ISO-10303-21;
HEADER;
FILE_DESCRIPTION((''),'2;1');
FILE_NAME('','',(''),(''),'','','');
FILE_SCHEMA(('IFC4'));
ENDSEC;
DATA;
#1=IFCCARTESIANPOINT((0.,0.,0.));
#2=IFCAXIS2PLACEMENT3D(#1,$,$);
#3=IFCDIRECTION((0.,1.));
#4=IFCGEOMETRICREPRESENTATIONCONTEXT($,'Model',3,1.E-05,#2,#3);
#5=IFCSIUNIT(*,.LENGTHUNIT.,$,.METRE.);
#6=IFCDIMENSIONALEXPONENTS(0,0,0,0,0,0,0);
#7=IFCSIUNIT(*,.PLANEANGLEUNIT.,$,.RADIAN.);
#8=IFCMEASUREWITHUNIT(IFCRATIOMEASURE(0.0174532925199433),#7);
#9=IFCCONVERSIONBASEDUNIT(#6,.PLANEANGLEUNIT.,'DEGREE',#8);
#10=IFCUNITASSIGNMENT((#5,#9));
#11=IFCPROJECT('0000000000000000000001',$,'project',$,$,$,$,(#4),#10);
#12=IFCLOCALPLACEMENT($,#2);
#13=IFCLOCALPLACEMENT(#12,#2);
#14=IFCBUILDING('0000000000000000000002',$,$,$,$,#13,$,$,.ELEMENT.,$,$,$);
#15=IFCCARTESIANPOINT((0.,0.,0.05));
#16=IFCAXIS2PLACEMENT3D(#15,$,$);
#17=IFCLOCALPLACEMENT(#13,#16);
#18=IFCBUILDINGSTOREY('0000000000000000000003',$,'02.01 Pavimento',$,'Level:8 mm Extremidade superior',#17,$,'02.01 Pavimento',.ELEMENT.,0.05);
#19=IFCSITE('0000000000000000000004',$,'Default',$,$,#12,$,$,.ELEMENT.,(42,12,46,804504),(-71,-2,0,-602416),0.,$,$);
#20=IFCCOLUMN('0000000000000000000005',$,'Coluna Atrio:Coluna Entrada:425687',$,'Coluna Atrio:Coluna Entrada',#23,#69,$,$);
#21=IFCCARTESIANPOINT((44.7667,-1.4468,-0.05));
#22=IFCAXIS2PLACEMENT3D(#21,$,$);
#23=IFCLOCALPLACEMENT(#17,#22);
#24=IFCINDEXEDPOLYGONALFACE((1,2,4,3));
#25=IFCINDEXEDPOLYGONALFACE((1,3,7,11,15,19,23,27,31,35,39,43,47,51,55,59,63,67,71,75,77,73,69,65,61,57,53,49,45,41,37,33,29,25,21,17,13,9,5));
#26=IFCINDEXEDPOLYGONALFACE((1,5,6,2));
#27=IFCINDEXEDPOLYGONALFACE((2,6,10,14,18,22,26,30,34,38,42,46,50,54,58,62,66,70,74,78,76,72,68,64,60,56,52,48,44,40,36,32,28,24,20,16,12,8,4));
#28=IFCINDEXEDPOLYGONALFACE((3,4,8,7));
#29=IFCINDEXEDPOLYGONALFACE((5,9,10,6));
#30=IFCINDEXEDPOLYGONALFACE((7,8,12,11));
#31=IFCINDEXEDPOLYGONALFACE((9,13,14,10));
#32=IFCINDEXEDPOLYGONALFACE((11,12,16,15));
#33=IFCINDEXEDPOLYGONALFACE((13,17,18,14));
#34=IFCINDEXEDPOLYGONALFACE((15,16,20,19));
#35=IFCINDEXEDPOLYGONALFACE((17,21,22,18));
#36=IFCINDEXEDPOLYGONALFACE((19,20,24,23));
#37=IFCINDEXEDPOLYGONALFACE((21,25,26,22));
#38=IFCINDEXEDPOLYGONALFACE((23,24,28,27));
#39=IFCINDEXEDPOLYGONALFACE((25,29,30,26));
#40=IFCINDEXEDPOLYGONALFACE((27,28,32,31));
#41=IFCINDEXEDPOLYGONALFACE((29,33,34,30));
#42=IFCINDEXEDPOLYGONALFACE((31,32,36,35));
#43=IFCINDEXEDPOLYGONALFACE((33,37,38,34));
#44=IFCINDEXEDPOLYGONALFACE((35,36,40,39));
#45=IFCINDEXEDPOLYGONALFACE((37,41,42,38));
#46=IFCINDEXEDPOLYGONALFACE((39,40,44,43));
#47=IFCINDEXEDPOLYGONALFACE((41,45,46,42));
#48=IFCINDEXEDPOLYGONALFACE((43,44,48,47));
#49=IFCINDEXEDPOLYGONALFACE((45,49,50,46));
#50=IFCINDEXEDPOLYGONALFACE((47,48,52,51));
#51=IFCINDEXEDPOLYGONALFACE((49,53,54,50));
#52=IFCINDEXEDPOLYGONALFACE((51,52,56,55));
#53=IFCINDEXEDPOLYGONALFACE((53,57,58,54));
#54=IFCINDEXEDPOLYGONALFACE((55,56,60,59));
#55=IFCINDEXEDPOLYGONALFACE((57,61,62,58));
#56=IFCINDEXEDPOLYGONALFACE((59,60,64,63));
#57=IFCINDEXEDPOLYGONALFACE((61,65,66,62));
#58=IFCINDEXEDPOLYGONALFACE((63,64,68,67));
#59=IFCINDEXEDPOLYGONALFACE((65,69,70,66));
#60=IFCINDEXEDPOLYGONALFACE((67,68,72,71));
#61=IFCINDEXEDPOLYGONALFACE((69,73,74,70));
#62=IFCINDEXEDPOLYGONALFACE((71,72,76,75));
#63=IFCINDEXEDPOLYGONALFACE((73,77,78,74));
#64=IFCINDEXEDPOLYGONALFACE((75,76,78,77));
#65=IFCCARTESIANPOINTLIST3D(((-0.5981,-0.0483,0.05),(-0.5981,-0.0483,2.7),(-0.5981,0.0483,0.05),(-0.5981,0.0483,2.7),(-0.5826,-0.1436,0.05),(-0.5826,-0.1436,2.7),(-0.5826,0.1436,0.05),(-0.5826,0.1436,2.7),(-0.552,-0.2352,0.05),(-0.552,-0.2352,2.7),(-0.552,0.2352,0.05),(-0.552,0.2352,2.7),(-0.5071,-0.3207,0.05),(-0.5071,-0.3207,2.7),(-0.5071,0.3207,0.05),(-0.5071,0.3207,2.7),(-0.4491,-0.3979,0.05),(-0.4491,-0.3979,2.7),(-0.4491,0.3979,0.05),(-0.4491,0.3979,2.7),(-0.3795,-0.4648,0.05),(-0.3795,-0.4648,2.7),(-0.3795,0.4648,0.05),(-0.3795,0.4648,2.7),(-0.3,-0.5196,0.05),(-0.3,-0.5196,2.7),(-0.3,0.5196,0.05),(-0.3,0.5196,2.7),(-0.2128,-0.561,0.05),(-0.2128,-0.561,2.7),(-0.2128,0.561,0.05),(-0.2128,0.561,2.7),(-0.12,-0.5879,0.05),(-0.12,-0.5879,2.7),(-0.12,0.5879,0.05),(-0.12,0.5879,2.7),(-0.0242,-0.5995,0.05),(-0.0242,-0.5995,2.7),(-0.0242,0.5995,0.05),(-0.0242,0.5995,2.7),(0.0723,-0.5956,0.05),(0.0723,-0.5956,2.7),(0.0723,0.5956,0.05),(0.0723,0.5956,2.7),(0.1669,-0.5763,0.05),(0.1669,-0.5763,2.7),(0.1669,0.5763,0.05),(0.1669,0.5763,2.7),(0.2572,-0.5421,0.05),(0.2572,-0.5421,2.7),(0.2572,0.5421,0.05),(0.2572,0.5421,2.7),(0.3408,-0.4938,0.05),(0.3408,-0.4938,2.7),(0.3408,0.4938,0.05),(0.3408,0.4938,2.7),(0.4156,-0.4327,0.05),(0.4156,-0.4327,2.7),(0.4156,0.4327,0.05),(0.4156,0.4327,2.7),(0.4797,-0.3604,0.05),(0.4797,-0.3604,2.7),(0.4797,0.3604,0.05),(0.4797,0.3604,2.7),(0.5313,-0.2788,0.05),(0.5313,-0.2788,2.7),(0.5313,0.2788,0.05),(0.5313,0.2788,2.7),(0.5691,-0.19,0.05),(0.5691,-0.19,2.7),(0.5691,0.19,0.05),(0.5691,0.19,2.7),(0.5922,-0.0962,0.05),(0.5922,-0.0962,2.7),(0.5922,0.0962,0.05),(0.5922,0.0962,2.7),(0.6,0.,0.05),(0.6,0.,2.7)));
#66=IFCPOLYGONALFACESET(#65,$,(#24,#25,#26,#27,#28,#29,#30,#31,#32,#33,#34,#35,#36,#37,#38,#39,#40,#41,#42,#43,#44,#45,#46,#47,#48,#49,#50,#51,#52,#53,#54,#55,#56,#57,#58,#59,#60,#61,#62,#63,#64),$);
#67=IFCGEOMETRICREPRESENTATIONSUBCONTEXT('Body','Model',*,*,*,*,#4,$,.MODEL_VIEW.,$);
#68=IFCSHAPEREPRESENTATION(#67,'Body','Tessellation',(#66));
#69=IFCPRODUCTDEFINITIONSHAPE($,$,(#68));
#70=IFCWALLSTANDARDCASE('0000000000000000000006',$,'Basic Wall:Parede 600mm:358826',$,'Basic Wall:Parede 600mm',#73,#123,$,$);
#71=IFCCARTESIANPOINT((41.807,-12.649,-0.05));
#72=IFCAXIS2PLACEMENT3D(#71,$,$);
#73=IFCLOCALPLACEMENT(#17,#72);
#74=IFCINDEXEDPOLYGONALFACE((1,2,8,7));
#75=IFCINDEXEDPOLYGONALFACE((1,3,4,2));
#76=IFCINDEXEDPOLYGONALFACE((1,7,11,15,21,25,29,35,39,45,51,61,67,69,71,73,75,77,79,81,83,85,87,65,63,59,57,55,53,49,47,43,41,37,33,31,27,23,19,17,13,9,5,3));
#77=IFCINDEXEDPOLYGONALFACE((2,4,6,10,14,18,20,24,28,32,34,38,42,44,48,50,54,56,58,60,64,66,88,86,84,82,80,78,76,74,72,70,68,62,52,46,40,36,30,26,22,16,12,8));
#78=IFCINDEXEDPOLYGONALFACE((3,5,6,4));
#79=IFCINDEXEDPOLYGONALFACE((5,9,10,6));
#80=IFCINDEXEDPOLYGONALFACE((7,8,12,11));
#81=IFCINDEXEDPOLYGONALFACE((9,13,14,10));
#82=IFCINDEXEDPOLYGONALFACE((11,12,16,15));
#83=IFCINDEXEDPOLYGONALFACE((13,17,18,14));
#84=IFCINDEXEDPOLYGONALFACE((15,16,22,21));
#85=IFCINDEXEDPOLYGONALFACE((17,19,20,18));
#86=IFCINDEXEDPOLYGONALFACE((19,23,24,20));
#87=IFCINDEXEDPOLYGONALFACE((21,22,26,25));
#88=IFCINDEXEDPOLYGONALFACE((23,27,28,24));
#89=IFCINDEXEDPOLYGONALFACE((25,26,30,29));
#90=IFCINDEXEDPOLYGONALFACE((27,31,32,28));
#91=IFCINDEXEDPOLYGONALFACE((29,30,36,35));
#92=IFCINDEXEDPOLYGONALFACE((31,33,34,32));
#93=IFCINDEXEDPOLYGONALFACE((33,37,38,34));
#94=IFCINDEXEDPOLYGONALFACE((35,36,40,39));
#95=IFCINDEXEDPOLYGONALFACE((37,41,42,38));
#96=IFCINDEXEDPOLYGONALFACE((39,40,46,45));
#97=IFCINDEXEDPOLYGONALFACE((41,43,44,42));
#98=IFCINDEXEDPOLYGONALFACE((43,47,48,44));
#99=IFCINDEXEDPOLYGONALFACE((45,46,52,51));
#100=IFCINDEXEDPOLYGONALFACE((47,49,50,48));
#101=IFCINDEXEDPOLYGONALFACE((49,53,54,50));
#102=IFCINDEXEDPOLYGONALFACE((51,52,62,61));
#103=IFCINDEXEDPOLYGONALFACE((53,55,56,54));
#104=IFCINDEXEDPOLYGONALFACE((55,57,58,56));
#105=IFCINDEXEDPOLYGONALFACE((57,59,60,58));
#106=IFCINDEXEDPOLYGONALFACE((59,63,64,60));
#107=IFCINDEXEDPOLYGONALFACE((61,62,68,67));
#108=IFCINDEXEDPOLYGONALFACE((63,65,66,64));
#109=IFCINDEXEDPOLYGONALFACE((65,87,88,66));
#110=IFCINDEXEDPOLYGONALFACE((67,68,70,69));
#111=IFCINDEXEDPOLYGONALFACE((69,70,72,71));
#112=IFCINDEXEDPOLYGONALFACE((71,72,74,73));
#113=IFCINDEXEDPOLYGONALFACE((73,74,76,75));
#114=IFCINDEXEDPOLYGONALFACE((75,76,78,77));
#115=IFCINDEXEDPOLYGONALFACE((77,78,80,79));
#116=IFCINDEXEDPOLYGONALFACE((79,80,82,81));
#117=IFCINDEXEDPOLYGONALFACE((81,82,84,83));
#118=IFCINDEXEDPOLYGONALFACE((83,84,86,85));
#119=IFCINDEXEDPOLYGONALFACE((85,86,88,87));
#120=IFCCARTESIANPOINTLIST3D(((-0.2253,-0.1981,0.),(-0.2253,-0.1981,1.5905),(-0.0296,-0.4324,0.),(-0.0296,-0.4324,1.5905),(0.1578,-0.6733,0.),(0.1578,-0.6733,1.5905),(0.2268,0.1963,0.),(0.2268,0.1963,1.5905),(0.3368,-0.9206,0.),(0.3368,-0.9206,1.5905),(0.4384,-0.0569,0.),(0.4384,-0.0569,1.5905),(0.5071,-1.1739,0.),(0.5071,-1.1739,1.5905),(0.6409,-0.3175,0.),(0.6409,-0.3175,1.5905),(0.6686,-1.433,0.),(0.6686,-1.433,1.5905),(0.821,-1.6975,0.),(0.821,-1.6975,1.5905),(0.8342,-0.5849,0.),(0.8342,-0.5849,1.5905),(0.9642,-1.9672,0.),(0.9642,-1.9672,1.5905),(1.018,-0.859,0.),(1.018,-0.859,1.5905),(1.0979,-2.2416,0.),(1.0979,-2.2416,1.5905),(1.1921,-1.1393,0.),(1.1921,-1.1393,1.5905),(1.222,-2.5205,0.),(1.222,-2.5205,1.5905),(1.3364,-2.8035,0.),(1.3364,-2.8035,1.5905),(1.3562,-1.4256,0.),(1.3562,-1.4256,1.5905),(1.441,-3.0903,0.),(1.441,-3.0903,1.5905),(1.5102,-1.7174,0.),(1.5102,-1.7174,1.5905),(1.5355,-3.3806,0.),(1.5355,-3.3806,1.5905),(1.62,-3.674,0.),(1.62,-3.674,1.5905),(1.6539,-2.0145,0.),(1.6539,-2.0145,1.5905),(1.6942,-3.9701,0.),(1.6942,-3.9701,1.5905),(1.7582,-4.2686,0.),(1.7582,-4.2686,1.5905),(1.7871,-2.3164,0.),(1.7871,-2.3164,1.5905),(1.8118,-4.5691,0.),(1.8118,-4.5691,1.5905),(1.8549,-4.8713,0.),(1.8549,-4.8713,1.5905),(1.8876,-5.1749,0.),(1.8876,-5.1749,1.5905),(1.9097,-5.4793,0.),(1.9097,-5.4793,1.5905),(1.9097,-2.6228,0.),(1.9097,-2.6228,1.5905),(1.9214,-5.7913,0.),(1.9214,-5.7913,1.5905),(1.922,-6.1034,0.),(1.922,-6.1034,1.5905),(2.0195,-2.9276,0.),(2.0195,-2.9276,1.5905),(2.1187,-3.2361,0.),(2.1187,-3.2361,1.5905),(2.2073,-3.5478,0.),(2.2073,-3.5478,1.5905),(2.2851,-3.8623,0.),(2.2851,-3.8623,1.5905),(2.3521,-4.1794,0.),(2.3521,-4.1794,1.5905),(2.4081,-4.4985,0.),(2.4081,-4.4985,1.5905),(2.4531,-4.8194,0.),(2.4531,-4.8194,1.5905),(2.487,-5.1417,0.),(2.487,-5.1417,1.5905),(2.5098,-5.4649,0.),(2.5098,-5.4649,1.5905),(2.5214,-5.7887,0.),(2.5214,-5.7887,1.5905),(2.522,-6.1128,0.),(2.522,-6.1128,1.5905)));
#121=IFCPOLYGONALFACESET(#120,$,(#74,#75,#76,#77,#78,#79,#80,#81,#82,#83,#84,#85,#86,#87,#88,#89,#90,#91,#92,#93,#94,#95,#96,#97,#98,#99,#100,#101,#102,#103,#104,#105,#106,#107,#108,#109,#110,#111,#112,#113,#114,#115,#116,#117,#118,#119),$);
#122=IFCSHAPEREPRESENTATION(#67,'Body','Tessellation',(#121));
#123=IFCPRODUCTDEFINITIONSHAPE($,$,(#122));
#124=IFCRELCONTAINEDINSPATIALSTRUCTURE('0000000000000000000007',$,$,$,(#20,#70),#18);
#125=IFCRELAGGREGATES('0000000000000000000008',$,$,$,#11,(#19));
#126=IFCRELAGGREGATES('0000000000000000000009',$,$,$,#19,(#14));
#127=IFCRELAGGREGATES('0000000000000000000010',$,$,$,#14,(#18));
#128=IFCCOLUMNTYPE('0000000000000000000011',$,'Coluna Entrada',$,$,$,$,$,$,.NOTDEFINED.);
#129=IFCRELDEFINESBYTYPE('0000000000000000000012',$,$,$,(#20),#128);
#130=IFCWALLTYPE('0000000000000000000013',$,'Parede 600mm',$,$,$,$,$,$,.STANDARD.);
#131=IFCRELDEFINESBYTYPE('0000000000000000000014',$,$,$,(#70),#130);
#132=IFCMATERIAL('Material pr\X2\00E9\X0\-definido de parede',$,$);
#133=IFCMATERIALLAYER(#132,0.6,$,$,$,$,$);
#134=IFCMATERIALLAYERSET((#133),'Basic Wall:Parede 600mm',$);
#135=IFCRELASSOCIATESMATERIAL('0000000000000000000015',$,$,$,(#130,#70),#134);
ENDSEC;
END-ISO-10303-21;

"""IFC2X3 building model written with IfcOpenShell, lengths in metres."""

from ifc_helpers import new_model, entity, si_unit, converted_unit, direction, frame, frame_2d, origin, place, context, subcontext, project, spatial, polyline, circle, outline, extrude, clip, halfspace, source, transform, mapped, material, layer, layer_set, layer_usage, type_object, type_shapes, element, save


model = new_model("IFC2X3")

# Units and contexts
model_context = context("Model", 3, precision=1e-05, world=origin(), true_north=direction((0.0, 1.0)))
body_context = subcontext(model_context, "Body", "Model", "MODEL_VIEW")
ifc_project = project(units=[si_unit("LENGTHUNIT", "METRE"), converted_unit("PLANEANGLEUNIT", "DEGREE", entity("IfcRatioMeasure", 0.0174532925199433), si_unit("PLANEANGLEUNIT", "RADIAN"), dimensions=[0, 0, 0, 0, 0, 0, 0])], contexts=[model_context])

# Site, building, storey
site_placement = place(None, origin())
site = spatial("IfcSite", under=ifc_project, at=site_placement, Name="Default", CompositionType="ELEMENT", RefLatitude=(42, 12, 46, 804504), RefLongitude=(-71, -2, 0, -602416), RefElevation=0.0)
building_placement = place(site_placement, origin())
building = spatial("IfcBuilding", under=site, at=building_placement, CompositionType="ELEMENT")
storey_placement = place(building_placement, frame((0.0, 0.0, 0.05)))
storey = spatial("IfcBuildingStorey", under=building, at=storey_placement, Name="02.01 Pavimento", ObjectType="Level:8 mm Extremidade superior", LongName="02.01 Pavimento", CompositionType="ELEMENT", Elevation=0.05)

# Column
column_type_1 = type_object("IfcColumnType", Name="Coluna Entrada", PredefinedType="NOTDEFINED")
shared_shape_1 = source(origin(), body_context, "Body", "SweptSolid", [
    extrude(circle(Radius=0.6, at=frame_2d((0.0, 0.0), x_axis=(1.0, 0.0))), frame((0.0, 0.0, 0.05)), (0.0, 0.0, 1.0), 2.65),
])
type_shapes(column_type_1, [shared_shape_1])
column_1_placement = place(storey_placement, frame((44.7667, -1.4468, -0.05)))
element("IfcColumn", 1, at=column_1_placement, inside=storey, type_object=column_type_1, Name="Coluna Atrio:Coluna Entrada:425687", ObjectType="Coluna Atrio:Coluna Entrada", context=body_context, shape_type="MappedRepresentation", body=[
    mapped(shared_shape_1, transform((0.0, 0.0, 0.0), scale=1.0)),
])

# Shared definitions
ifc_material_1 = material(Name="Material pré-definido de parede")

# Wall
ifc_layer_1 = layer(ifc_material_1, 0.6)
ifc_layer_set_1 = layer_set([ifc_layer_1], Name="Basic Wall:Parede 600mm")
ifc_layer_usage_1 = layer_usage(ifc_layer_set_1, "AXIS2", "NEGATIVE", 0.3)
wall_type_1 = type_object("IfcWallType", Name="Parede 600mm", PredefinedType="STANDARD", material=ifc_layer_set_1)
wall_1_placement = place(storey_placement, frame((41.807, -12.649, -0.05)))
element("IfcWallStandardCase", 2, at=wall_1_placement, inside=storey, type_object=wall_type_1, material=ifc_layer_usage_1, Name="Basic Wall:Parede 600mm:358826", ObjectType="Basic Wall:Parede 600mm", context=body_context, shape_type="Clipping", body=[
    clip(extrude(outline(polyline([(2.522, -6.1128), (2.5214, -5.7887), (2.5098, -5.4649), (2.487, -5.1417), (2.4531, -4.8194), (2.4081, -4.4985), (2.3521, -4.1794), (2.2851, -3.8623), (2.2073, -3.5478), (2.1187, -3.2361), (2.0195, -2.9276), (1.9097, -2.6228), (1.7871, -2.3164), (1.6539, -2.0145), (1.5102, -1.7174), (1.3562, -1.4256), (1.1921, -1.1393), (1.018, -0.859), (0.8342, -0.5849), (0.6409, -0.3175), (0.4384, -0.0569), (0.2268, 0.1963), (-0.2253, -0.1981), (-0.0296, -0.4324), (0.1578, -0.6733), (0.3368, -0.9206), (0.5071, -1.1739), (0.6686, -1.433), (0.821, -1.6975), (0.9642, -1.9672), (1.0979, -2.2416), (1.222, -2.5205), (1.3364, -2.8035), (1.441, -3.0903), (1.5355, -3.3806), (1.62, -3.674), (1.6942, -3.9701), (1.7582, -4.2686), (1.8118, -4.5691), (1.8549, -4.8713), (1.8876, -5.1749), (1.9097, -5.4793), (1.9214, -5.7913), (1.922, -6.1034), (2.522, -6.1128)])), origin(), (0.0, 0.0, 1.0), 1.5905), halfspace(frame((0.0, 0.0, -0.05)), True)),
])

save(model, "model.ifc")
